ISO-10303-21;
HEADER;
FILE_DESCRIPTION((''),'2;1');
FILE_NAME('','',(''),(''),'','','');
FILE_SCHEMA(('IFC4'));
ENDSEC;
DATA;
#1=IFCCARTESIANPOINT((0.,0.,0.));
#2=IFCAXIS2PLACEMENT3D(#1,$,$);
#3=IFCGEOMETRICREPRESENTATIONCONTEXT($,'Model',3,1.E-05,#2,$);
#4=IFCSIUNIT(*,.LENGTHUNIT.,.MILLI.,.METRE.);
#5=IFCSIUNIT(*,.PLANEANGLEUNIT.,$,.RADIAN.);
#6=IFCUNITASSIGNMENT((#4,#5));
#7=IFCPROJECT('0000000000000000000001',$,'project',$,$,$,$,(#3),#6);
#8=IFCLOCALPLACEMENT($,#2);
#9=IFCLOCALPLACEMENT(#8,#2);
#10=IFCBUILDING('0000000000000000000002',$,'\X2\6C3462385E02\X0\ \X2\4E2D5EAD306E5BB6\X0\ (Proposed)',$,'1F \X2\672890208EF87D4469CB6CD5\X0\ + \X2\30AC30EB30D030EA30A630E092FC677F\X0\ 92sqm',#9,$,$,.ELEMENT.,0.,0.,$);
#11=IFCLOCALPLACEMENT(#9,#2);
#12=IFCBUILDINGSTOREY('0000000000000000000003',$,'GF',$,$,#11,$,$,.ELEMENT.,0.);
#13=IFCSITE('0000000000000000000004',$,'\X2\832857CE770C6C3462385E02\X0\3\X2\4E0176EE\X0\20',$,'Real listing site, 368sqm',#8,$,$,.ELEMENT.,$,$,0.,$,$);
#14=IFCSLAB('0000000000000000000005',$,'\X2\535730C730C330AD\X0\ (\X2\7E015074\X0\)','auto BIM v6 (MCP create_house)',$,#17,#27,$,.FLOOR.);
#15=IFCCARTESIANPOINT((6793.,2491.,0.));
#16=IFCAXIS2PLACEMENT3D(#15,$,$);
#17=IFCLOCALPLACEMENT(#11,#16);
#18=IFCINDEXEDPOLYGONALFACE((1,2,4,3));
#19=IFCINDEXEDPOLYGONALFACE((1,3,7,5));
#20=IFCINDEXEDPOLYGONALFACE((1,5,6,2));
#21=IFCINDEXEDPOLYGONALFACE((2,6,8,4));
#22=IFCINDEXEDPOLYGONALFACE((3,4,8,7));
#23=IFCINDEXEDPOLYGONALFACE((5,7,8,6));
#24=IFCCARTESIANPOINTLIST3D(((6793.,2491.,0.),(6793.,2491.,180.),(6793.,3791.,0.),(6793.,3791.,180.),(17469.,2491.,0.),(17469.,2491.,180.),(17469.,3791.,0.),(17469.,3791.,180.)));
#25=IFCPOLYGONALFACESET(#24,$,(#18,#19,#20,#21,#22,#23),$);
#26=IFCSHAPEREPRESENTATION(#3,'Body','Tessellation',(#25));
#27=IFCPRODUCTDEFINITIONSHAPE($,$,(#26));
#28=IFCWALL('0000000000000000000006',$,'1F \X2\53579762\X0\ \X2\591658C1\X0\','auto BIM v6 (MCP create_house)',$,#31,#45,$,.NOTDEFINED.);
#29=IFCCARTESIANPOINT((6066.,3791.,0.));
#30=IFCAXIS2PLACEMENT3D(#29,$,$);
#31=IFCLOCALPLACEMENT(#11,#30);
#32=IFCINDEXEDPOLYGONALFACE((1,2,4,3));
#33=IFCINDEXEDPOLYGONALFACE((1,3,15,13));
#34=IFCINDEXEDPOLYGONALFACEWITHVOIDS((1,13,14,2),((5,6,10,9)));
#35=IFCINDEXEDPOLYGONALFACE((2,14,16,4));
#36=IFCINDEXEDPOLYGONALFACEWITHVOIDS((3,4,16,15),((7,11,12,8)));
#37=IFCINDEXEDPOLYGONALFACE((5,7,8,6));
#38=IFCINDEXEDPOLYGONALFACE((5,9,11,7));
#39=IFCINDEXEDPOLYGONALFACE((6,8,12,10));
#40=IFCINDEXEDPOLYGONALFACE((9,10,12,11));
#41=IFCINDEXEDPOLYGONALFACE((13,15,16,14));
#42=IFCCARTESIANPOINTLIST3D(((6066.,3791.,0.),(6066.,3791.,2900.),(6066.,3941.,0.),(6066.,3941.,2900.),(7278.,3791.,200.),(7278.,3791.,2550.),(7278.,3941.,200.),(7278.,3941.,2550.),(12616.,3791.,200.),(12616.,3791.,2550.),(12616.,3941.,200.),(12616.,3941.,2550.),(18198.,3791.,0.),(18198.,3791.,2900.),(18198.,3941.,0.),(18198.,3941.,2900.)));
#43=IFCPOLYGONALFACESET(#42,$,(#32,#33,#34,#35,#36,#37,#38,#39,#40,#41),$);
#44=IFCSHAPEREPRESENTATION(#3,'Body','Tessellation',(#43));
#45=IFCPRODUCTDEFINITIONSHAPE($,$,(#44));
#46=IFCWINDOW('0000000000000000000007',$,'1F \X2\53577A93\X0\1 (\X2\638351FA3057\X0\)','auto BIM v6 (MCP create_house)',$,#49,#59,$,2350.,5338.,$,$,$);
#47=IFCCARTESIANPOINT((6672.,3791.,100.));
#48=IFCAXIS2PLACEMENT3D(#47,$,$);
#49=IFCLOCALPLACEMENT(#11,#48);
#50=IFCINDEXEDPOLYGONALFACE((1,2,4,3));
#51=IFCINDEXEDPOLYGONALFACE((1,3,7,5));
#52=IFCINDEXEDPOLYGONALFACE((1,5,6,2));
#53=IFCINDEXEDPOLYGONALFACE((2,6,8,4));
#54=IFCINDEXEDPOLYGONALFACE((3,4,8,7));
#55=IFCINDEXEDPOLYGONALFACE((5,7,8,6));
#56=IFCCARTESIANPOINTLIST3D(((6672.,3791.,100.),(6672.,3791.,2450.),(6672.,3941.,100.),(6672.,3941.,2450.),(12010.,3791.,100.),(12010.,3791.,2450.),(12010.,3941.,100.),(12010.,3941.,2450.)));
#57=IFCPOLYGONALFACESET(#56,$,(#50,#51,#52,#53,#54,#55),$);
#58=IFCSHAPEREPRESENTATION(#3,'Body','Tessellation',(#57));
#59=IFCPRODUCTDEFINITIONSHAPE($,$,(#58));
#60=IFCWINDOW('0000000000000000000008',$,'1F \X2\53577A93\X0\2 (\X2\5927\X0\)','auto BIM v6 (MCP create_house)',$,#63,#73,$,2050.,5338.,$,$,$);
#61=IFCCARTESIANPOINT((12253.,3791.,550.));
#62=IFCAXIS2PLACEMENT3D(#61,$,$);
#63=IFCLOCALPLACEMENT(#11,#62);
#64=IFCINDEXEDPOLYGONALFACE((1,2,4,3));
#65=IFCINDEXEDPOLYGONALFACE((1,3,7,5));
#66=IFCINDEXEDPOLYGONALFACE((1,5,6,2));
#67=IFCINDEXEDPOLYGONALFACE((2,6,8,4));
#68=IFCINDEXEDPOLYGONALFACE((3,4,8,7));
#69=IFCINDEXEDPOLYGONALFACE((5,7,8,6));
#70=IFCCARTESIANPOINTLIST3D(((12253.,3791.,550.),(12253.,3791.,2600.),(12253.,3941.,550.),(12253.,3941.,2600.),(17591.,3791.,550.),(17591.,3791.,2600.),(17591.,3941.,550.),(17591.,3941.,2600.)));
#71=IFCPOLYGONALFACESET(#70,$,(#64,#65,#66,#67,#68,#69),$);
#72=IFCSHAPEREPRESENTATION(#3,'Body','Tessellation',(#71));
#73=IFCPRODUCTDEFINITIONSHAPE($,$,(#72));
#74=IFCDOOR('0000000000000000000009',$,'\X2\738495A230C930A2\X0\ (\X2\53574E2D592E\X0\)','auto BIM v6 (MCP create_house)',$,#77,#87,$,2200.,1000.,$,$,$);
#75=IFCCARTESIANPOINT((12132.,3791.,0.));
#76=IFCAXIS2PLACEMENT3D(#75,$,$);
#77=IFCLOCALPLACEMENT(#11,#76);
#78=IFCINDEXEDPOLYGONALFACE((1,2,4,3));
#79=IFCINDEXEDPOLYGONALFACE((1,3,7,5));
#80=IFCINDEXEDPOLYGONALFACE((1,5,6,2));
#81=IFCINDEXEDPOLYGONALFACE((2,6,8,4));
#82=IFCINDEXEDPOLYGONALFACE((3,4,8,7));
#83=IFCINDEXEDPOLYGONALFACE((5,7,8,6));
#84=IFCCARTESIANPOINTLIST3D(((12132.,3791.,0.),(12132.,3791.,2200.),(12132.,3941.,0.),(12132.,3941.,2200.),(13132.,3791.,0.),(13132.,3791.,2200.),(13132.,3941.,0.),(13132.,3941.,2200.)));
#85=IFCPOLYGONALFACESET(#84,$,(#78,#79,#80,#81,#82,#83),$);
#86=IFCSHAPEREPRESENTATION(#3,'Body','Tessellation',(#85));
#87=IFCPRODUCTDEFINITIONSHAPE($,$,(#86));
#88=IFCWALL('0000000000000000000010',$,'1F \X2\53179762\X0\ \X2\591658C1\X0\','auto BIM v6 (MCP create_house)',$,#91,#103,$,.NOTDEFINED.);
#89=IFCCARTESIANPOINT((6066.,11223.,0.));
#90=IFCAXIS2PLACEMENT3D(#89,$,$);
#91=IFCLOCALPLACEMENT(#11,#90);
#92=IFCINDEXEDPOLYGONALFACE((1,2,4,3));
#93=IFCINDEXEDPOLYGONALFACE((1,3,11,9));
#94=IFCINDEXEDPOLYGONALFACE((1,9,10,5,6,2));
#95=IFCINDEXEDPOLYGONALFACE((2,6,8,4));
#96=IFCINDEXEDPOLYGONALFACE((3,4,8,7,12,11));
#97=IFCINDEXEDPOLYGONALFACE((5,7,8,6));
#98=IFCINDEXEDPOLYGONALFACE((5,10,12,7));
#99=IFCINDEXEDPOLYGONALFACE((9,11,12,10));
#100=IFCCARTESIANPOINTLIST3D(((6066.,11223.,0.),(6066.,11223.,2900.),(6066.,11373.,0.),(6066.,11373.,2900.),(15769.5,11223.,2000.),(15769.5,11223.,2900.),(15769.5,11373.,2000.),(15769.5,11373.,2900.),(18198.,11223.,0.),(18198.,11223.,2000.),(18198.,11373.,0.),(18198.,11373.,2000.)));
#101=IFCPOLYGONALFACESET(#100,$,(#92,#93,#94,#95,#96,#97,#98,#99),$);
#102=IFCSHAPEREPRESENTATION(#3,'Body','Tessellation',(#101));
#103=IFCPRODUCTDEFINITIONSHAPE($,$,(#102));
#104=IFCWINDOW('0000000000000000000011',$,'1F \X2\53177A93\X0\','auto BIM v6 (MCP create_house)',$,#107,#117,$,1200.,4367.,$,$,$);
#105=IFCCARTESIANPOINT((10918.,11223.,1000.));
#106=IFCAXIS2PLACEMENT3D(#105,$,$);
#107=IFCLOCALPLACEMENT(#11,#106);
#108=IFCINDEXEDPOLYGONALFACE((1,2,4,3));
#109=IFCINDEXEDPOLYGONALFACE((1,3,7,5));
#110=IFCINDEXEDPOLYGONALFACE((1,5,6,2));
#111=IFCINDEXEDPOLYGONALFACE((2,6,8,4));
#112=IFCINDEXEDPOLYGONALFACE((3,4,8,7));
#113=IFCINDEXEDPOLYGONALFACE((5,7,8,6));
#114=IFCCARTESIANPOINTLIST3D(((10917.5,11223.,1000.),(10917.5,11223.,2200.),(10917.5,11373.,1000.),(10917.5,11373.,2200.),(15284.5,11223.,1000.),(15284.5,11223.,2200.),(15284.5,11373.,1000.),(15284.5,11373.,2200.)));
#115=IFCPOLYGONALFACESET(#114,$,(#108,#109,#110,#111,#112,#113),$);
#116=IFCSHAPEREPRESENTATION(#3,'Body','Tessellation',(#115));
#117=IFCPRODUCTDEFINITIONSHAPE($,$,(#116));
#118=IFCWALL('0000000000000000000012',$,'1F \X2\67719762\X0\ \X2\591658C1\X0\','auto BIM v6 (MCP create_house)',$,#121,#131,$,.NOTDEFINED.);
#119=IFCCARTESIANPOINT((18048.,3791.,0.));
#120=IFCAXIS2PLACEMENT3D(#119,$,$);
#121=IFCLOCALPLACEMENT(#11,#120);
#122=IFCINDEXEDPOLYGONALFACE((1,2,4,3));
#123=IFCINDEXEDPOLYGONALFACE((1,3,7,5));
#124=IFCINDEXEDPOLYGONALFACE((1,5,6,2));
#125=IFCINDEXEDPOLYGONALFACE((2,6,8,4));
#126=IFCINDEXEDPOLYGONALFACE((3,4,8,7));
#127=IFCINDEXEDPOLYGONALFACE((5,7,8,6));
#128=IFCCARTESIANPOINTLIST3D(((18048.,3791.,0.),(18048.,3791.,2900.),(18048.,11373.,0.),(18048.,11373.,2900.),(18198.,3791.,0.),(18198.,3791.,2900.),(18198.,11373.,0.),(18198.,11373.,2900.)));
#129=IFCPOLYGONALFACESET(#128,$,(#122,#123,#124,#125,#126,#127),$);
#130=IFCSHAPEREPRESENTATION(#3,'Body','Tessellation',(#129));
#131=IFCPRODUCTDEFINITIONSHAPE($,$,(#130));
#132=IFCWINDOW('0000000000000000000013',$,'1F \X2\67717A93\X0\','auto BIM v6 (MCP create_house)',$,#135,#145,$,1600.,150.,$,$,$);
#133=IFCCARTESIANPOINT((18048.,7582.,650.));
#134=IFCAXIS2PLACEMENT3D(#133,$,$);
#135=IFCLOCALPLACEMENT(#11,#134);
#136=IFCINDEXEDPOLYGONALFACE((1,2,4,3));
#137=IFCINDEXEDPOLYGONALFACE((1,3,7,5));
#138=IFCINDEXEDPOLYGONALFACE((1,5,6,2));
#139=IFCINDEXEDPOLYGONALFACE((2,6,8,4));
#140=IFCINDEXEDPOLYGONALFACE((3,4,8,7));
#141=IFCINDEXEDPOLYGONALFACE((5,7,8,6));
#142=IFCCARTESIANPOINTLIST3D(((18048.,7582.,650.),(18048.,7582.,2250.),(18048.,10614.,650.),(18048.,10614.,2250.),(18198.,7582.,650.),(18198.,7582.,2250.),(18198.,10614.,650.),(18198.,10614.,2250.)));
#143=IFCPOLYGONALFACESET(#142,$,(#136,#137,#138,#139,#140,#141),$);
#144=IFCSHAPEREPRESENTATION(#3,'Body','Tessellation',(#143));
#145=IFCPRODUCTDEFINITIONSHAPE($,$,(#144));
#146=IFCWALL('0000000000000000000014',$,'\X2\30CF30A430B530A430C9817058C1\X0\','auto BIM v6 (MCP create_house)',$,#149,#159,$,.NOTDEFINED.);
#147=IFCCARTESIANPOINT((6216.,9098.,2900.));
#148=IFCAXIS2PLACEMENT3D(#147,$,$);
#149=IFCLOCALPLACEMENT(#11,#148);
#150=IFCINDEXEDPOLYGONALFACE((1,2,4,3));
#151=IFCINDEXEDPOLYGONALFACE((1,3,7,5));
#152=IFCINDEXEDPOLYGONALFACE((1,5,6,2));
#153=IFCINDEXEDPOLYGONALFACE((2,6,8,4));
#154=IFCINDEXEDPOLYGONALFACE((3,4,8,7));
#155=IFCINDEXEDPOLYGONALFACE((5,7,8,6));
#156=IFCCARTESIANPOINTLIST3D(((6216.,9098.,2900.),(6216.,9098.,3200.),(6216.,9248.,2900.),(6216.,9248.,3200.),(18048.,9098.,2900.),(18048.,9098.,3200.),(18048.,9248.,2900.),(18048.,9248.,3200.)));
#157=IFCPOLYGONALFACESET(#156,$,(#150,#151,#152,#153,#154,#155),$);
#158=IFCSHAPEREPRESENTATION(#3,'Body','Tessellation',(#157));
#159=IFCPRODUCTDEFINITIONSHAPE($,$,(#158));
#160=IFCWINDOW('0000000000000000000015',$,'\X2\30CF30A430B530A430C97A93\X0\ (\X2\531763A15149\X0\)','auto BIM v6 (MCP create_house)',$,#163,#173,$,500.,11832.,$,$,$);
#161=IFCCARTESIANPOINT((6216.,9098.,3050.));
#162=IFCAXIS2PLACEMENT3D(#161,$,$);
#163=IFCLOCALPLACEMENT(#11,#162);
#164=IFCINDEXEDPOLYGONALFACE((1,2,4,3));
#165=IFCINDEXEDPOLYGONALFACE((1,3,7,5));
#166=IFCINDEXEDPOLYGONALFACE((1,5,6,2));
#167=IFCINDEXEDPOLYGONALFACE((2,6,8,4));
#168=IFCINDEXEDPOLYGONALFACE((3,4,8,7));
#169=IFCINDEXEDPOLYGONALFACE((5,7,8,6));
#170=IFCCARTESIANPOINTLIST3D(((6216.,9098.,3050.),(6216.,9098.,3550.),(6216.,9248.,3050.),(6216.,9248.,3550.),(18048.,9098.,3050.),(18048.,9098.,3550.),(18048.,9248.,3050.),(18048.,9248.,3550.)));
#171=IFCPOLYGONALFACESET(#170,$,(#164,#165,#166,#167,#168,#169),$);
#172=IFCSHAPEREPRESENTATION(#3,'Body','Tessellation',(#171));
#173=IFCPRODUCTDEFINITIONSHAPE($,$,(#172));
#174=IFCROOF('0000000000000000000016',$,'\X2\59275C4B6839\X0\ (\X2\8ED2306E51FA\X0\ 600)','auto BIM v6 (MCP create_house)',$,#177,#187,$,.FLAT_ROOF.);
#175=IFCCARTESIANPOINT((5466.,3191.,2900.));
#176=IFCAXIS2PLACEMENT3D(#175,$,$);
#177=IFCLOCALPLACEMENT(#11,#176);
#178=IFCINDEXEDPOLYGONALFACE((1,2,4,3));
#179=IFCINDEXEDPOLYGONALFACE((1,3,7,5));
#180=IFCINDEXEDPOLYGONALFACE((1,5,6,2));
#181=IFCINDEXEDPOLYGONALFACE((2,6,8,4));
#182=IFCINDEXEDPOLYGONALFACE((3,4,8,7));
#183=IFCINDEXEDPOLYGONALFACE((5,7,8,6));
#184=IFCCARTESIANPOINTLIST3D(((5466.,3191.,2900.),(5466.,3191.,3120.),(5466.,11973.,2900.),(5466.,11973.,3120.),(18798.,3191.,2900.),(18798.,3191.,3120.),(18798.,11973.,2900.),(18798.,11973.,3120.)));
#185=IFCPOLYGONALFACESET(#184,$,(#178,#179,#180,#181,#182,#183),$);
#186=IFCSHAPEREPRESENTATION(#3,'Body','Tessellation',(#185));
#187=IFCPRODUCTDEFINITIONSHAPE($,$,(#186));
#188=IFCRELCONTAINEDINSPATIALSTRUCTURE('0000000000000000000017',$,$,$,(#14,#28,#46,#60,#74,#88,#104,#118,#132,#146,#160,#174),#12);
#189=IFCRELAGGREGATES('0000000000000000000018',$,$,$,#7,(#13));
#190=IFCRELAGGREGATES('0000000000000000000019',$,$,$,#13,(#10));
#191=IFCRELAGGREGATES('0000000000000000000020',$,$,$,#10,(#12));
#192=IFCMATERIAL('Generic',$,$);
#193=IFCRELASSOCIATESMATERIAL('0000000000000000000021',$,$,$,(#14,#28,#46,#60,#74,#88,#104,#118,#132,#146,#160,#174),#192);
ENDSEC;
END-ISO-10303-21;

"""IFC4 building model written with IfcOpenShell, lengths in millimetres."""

from ifc_helpers import new_model, si_unit, frame, frame_2d, origin, place, context, project, spatial, rectangle, extrude, material, element, fill, save


model = new_model("IFC4")

# Units and contexts
model_context = context("Model", 3, precision=1e-05, world=origin())
ifc_project = project(units=[si_unit("LENGTHUNIT", "METRE", prefix="MILLI"), si_unit("PLANEANGLEUNIT", "RADIAN")], contexts=[model_context])

# Site, building, storey
site_placement = place(None, origin())
site = spatial("IfcSite", under=ifc_project, at=site_placement, Name="茨城県水戸市3丁目20", ObjectType="Real listing site, 368sqm", CompositionType="ELEMENT", RefElevation=0.0)
building_placement = place(site_placement, origin())
building = spatial("IfcBuilding", under=site, at=building_placement, Name="水戸市 中庭の家 (Proposed)", ObjectType="1F 木造軸組構法 + ガルバリウム鋼板 92sqm", CompositionType="ELEMENT", ElevationOfRefHeight=0.0, ElevationOfTerrain=0.0)
storey_placement = place(building_placement, origin())
storey = spatial("IfcBuildingStorey", under=building, at=storey_placement, Name="GF", CompositionType="ELEMENT", Elevation=0.0)

# Slab
ifc_material = material(Name="Generic")
slab_1_placement = place(storey_placement, frame((6793.0, 2491.0, 0.0)))
element("IfcSlab", 1, at=slab_1_placement, inside=storey, material=ifc_material, Name="南デッキ (縁側)", Description="auto BIM v6 (MCP create_house)", PredefinedType="FLOOR", context=model_context, shape_type="SweptSolid", body=[
    extrude(rectangle(XDim=10676.0, YDim=1300.0, at=frame_2d((5338.0, 650.0))), frame((6793.0, 2491.0, 0.0)), (0.0, 0.0, 1.0), 180.0),
])

# Wall, openings, windows, door
wall_1_placement = place(storey_placement, frame((6066.0, 3791.0, 0.0)))
wall_1 = element("IfcWall", 2, at=wall_1_placement, inside=storey, material=ifc_material, Name="1F 南面 外壁", Description="auto BIM v6 (MCP create_house)", PredefinedType="NOTDEFINED", context=model_context, shape_type="SweptSolid", body=[
    extrude(rectangle(XDim=12132.0, YDim=150.0, at=frame_2d((6066.0, 75.0))), frame((6066.0, 3791.0, 0.0)), (0.0, 0.0, 1.0), 2900.0),
])
opening_1_placement = place(storey_placement, frame((6672.0, 3791.0, 100.0)))
opening_1 = element("IfcOpeningElement", 3, at=opening_1_placement, cuts=wall_1, PredefinedType="NOTDEFINED", context=model_context, shape_type="SweptSolid", body=[
    extrude(rectangle(XDim=5338.0, YDim=150.0, at=frame_2d((2669.0, 75.0))), frame((6672.0, 3791.0, 100.0)), (0.0, 0.0, 1.0), 2350.0),
])
opening_2_placement = place(storey_placement, frame((12253.0, 3791.0, 550.0)))
opening_2 = element("IfcOpeningElement", 4, at=opening_2_placement, cuts=wall_1, PredefinedType="NOTDEFINED", context=model_context, shape_type="SweptSolid", body=[
    extrude(rectangle(XDim=5338.0, YDim=150.0, at=frame_2d((2669.0, 75.0))), frame((12253.0, 3791.0, 550.0)), (0.0, 0.0, 1.0), 2050.0),
])
opening_3_placement = place(storey_placement, frame((12132.0, 3791.0, 0.0)))
opening_3 = element("IfcOpeningElement", 5, at=opening_3_placement, cuts=wall_1, PredefinedType="NOTDEFINED", context=model_context, shape_type="SweptSolid", body=[
    extrude(rectangle(XDim=1000.0, YDim=150.0, at=frame_2d((500.0, 75.0))), frame((12132.0, 3791.0, 0.0)), (0.0, 0.0, 1.0), 2200.0),
])
window_1_placement = place(storey_placement, frame((6672.0, 3791.0, 100.0)))
window_1 = element("IfcWindow", 6, at=window_1_placement, inside=storey, material=ifc_material, Name="1F 南窓1 (掃出し)", Description="auto BIM v6 (MCP create_house)", OverallHeight=2350.0, OverallWidth=5338.0, context=model_context, shape_type="SweptSolid", body=[
    extrude(rectangle(XDim=5338.0, YDim=150.0, at=frame_2d((2669.0, 75.0))), frame((6672.0, 3791.0, 100.0)), (0.0, 0.0, 1.0), 2350.0),
])
fill(opening_1, window_1)
window_2_placement = place(storey_placement, frame((12253.0, 3791.0, 550.0)))
window_2 = element("IfcWindow", 7, at=window_2_placement, inside=storey, material=ifc_material, Name="1F 南窓2 (大)", Description="auto BIM v6 (MCP create_house)", OverallHeight=2050.0, OverallWidth=5338.0, context=model_context, shape_type="SweptSolid", body=[
    extrude(rectangle(XDim=5338.0, YDim=150.0, at=frame_2d((2669.0, 75.0))), frame((12253.0, 3791.0, 550.0)), (0.0, 0.0, 1.0), 2050.0),
])
fill(opening_2, window_2)
door_placement = place(storey_placement, frame((12132.0, 3791.0, 0.0)))
door = element("IfcDoor", 8, at=door_placement, inside=storey, material=ifc_material, Name="玄関ドア (南中央)", Description="auto BIM v6 (MCP create_house)", OverallHeight=2200.0, OverallWidth=1000.0, context=model_context, shape_type="SweptSolid", body=[
    extrude(rectangle(XDim=1000.0, YDim=150.0, at=frame_2d((500.0, 75.0))), frame((12132.0, 3791.0, 0.0)), (0.0, 0.0, 1.0), 2200.0),
])
fill(opening_3, door)

# Walls, openings, windows
wall_2_placement = place(storey_placement, frame((6066.0, 11223.0, 0.0)))
wall_2 = element("IfcWall", 9, at=wall_2_placement, inside=storey, material=ifc_material, Name="1F 北面 外壁", Description="auto BIM v6 (MCP create_house)", PredefinedType="NOTDEFINED", context=model_context, shape_type="SweptSolid", body=[
    extrude(rectangle(XDim=12132.0, YDim=150.0, at=frame_2d((6066.0, 75.0))), frame((6066.0, 11223.0, 0.0)), (0.0, 0.0, 1.0), 2900.0),
])
opening_4_placement = place(storey_placement, frame((10918.0, 11223.0, 1000.0)))
opening_4 = element("IfcOpeningElement", 10, at=opening_4_placement, cuts=wall_2, PredefinedType="NOTDEFINED", context=model_context, shape_type="SweptSolid", body=[
    extrude(rectangle(XDim=4367.0, YDim=150.0, at=frame_2d((2183.0, 75.0))), frame((10918.0, 11223.0, 1000.0)), (0.0, 0.0, 1.0), 1200.0),
])
window_3_placement = place(storey_placement, frame((10918.0, 11223.0, 1000.0)))
window_3 = element("IfcWindow", 11, at=window_3_placement, inside=storey, material=ifc_material, Name="1F 北窓", Description="auto BIM v6 (MCP create_house)", OverallHeight=1200.0, OverallWidth=4367.0, context=model_context, shape_type="SweptSolid", body=[
    extrude(rectangle(XDim=4367.0, YDim=150.0, at=frame_2d((2183.0, 75.0))), frame((10918.0, 11223.0, 1000.0)), (0.0, 0.0, 1.0), 1200.0),
])
fill(opening_4, window_3)
wall_3_placement = place(storey_placement, frame((18048.0, 3791.0, 0.0)))
wall_3 = element("IfcWall", 12, at=wall_3_placement, inside=storey, material=ifc_material, Name="1F 東面 外壁", Description="auto BIM v6 (MCP create_house)", PredefinedType="NOTDEFINED", context=model_context, shape_type="SweptSolid", body=[
    extrude(rectangle(XDim=150.0, YDim=7582.0, at=frame_2d((75.0, 3791.0))), frame((18048.0, 3791.0, 0.0)), (0.0, 0.0, 1.0), 2900.0),
])
opening_5_placement = place(storey_placement, frame((18048.0, 7582.0, 650.0)))
opening_5 = element("IfcOpeningElement", 13, at=opening_5_placement, cuts=wall_3, PredefinedType="NOTDEFINED", context=model_context, shape_type="SweptSolid", body=[
    extrude(rectangle(XDim=150.0, YDim=3032.0, at=frame_2d((75.0, 1516.0))), frame((18048.0, 7582.0, 650.0)), (0.0, 0.0, 1.0), 1600.0),
])
window_4_placement = place(storey_placement, frame((18048.0, 7582.0, 650.0)))
window_4 = element("IfcWindow", 14, at=window_4_placement, inside=storey, material=ifc_material, Name="1F 東窓", Description="auto BIM v6 (MCP create_house)", OverallHeight=1600.0, OverallWidth=150.0, context=model_context, shape_type="SweptSolid", body=[
    extrude(rectangle(XDim=150.0, YDim=3032.0, at=frame_2d((75.0, 1516.0))), frame((18048.0, 7582.0, 650.0)), (0.0, 0.0, 1.0), 1600.0),
])
fill(opening_5, window_4)

# Wall, opening, window
wall_4_placement = place(storey_placement, frame((6216.0, 9098.0, 2900.0)))
wall_4 = element("IfcWall", 15, at=wall_4_placement, inside=storey, material=ifc_material, Name="ハイサイド腰壁", Description="auto BIM v6 (MCP create_house)", PredefinedType="NOTDEFINED", context=model_context, shape_type="SweptSolid", body=[
    extrude(rectangle(XDim=11832.0, YDim=150.0, at=frame_2d((5916.0, 75.0))), frame((6216.0, 9098.0, 2900.0)), (0.0, 0.0, 1.0), 700.0),
])
opening_6_placement = place(storey_placement, frame((6216.0, 9098.0, 3050.0)))
opening_6 = element("IfcOpeningElement", 16, at=opening_6_placement, cuts=wall_4, PredefinedType="NOTDEFINED", context=model_context, shape_type="SweptSolid", body=[
    extrude(rectangle(XDim=11832.0, YDim=150.0, at=frame_2d((5916.0, 75.0))), frame((6216.0, 9098.0, 3050.0)), (0.0, 0.0, 1.0), 500.0),
])
window_5_placement = place(storey_placement, frame((6216.0, 9098.0, 3050.0)))
window_5 = element("IfcWindow", 17, at=window_5_placement, inside=storey, material=ifc_material, Name="ハイサイド窓 (北採光)", Description="auto BIM v6 (MCP create_house)", OverallHeight=500.0, OverallWidth=11832.0, context=model_context, shape_type="SweptSolid", body=[
    extrude(rectangle(XDim=11832.0, YDim=150.0, at=frame_2d((5916.0, 75.0))), frame((6216.0, 9098.0, 3050.0)), (0.0, 0.0, 1.0), 500.0),
])
fill(opening_6, window_5)

# Roof
roof_1_placement = place(storey_placement, frame((5466.0, 3191.0, 2900.0)))
element("IfcRoof", 18, at=roof_1_placement, inside=storey, material=ifc_material, Name="大屋根 (軒の出 600)", Description="auto BIM v6 (MCP create_house)", PredefinedType="FLAT_ROOF", context=model_context, shape_type="SweptSolid", body=[
    extrude(rectangle(XDim=13332.0, YDim=8782.0, at=frame_2d((6666.0, 4391.0))), frame((5466.0, 3191.0, 2900.0)), (0.0, 0.0, 1.0), 220.0),
])

save(model, "model.ifc")
